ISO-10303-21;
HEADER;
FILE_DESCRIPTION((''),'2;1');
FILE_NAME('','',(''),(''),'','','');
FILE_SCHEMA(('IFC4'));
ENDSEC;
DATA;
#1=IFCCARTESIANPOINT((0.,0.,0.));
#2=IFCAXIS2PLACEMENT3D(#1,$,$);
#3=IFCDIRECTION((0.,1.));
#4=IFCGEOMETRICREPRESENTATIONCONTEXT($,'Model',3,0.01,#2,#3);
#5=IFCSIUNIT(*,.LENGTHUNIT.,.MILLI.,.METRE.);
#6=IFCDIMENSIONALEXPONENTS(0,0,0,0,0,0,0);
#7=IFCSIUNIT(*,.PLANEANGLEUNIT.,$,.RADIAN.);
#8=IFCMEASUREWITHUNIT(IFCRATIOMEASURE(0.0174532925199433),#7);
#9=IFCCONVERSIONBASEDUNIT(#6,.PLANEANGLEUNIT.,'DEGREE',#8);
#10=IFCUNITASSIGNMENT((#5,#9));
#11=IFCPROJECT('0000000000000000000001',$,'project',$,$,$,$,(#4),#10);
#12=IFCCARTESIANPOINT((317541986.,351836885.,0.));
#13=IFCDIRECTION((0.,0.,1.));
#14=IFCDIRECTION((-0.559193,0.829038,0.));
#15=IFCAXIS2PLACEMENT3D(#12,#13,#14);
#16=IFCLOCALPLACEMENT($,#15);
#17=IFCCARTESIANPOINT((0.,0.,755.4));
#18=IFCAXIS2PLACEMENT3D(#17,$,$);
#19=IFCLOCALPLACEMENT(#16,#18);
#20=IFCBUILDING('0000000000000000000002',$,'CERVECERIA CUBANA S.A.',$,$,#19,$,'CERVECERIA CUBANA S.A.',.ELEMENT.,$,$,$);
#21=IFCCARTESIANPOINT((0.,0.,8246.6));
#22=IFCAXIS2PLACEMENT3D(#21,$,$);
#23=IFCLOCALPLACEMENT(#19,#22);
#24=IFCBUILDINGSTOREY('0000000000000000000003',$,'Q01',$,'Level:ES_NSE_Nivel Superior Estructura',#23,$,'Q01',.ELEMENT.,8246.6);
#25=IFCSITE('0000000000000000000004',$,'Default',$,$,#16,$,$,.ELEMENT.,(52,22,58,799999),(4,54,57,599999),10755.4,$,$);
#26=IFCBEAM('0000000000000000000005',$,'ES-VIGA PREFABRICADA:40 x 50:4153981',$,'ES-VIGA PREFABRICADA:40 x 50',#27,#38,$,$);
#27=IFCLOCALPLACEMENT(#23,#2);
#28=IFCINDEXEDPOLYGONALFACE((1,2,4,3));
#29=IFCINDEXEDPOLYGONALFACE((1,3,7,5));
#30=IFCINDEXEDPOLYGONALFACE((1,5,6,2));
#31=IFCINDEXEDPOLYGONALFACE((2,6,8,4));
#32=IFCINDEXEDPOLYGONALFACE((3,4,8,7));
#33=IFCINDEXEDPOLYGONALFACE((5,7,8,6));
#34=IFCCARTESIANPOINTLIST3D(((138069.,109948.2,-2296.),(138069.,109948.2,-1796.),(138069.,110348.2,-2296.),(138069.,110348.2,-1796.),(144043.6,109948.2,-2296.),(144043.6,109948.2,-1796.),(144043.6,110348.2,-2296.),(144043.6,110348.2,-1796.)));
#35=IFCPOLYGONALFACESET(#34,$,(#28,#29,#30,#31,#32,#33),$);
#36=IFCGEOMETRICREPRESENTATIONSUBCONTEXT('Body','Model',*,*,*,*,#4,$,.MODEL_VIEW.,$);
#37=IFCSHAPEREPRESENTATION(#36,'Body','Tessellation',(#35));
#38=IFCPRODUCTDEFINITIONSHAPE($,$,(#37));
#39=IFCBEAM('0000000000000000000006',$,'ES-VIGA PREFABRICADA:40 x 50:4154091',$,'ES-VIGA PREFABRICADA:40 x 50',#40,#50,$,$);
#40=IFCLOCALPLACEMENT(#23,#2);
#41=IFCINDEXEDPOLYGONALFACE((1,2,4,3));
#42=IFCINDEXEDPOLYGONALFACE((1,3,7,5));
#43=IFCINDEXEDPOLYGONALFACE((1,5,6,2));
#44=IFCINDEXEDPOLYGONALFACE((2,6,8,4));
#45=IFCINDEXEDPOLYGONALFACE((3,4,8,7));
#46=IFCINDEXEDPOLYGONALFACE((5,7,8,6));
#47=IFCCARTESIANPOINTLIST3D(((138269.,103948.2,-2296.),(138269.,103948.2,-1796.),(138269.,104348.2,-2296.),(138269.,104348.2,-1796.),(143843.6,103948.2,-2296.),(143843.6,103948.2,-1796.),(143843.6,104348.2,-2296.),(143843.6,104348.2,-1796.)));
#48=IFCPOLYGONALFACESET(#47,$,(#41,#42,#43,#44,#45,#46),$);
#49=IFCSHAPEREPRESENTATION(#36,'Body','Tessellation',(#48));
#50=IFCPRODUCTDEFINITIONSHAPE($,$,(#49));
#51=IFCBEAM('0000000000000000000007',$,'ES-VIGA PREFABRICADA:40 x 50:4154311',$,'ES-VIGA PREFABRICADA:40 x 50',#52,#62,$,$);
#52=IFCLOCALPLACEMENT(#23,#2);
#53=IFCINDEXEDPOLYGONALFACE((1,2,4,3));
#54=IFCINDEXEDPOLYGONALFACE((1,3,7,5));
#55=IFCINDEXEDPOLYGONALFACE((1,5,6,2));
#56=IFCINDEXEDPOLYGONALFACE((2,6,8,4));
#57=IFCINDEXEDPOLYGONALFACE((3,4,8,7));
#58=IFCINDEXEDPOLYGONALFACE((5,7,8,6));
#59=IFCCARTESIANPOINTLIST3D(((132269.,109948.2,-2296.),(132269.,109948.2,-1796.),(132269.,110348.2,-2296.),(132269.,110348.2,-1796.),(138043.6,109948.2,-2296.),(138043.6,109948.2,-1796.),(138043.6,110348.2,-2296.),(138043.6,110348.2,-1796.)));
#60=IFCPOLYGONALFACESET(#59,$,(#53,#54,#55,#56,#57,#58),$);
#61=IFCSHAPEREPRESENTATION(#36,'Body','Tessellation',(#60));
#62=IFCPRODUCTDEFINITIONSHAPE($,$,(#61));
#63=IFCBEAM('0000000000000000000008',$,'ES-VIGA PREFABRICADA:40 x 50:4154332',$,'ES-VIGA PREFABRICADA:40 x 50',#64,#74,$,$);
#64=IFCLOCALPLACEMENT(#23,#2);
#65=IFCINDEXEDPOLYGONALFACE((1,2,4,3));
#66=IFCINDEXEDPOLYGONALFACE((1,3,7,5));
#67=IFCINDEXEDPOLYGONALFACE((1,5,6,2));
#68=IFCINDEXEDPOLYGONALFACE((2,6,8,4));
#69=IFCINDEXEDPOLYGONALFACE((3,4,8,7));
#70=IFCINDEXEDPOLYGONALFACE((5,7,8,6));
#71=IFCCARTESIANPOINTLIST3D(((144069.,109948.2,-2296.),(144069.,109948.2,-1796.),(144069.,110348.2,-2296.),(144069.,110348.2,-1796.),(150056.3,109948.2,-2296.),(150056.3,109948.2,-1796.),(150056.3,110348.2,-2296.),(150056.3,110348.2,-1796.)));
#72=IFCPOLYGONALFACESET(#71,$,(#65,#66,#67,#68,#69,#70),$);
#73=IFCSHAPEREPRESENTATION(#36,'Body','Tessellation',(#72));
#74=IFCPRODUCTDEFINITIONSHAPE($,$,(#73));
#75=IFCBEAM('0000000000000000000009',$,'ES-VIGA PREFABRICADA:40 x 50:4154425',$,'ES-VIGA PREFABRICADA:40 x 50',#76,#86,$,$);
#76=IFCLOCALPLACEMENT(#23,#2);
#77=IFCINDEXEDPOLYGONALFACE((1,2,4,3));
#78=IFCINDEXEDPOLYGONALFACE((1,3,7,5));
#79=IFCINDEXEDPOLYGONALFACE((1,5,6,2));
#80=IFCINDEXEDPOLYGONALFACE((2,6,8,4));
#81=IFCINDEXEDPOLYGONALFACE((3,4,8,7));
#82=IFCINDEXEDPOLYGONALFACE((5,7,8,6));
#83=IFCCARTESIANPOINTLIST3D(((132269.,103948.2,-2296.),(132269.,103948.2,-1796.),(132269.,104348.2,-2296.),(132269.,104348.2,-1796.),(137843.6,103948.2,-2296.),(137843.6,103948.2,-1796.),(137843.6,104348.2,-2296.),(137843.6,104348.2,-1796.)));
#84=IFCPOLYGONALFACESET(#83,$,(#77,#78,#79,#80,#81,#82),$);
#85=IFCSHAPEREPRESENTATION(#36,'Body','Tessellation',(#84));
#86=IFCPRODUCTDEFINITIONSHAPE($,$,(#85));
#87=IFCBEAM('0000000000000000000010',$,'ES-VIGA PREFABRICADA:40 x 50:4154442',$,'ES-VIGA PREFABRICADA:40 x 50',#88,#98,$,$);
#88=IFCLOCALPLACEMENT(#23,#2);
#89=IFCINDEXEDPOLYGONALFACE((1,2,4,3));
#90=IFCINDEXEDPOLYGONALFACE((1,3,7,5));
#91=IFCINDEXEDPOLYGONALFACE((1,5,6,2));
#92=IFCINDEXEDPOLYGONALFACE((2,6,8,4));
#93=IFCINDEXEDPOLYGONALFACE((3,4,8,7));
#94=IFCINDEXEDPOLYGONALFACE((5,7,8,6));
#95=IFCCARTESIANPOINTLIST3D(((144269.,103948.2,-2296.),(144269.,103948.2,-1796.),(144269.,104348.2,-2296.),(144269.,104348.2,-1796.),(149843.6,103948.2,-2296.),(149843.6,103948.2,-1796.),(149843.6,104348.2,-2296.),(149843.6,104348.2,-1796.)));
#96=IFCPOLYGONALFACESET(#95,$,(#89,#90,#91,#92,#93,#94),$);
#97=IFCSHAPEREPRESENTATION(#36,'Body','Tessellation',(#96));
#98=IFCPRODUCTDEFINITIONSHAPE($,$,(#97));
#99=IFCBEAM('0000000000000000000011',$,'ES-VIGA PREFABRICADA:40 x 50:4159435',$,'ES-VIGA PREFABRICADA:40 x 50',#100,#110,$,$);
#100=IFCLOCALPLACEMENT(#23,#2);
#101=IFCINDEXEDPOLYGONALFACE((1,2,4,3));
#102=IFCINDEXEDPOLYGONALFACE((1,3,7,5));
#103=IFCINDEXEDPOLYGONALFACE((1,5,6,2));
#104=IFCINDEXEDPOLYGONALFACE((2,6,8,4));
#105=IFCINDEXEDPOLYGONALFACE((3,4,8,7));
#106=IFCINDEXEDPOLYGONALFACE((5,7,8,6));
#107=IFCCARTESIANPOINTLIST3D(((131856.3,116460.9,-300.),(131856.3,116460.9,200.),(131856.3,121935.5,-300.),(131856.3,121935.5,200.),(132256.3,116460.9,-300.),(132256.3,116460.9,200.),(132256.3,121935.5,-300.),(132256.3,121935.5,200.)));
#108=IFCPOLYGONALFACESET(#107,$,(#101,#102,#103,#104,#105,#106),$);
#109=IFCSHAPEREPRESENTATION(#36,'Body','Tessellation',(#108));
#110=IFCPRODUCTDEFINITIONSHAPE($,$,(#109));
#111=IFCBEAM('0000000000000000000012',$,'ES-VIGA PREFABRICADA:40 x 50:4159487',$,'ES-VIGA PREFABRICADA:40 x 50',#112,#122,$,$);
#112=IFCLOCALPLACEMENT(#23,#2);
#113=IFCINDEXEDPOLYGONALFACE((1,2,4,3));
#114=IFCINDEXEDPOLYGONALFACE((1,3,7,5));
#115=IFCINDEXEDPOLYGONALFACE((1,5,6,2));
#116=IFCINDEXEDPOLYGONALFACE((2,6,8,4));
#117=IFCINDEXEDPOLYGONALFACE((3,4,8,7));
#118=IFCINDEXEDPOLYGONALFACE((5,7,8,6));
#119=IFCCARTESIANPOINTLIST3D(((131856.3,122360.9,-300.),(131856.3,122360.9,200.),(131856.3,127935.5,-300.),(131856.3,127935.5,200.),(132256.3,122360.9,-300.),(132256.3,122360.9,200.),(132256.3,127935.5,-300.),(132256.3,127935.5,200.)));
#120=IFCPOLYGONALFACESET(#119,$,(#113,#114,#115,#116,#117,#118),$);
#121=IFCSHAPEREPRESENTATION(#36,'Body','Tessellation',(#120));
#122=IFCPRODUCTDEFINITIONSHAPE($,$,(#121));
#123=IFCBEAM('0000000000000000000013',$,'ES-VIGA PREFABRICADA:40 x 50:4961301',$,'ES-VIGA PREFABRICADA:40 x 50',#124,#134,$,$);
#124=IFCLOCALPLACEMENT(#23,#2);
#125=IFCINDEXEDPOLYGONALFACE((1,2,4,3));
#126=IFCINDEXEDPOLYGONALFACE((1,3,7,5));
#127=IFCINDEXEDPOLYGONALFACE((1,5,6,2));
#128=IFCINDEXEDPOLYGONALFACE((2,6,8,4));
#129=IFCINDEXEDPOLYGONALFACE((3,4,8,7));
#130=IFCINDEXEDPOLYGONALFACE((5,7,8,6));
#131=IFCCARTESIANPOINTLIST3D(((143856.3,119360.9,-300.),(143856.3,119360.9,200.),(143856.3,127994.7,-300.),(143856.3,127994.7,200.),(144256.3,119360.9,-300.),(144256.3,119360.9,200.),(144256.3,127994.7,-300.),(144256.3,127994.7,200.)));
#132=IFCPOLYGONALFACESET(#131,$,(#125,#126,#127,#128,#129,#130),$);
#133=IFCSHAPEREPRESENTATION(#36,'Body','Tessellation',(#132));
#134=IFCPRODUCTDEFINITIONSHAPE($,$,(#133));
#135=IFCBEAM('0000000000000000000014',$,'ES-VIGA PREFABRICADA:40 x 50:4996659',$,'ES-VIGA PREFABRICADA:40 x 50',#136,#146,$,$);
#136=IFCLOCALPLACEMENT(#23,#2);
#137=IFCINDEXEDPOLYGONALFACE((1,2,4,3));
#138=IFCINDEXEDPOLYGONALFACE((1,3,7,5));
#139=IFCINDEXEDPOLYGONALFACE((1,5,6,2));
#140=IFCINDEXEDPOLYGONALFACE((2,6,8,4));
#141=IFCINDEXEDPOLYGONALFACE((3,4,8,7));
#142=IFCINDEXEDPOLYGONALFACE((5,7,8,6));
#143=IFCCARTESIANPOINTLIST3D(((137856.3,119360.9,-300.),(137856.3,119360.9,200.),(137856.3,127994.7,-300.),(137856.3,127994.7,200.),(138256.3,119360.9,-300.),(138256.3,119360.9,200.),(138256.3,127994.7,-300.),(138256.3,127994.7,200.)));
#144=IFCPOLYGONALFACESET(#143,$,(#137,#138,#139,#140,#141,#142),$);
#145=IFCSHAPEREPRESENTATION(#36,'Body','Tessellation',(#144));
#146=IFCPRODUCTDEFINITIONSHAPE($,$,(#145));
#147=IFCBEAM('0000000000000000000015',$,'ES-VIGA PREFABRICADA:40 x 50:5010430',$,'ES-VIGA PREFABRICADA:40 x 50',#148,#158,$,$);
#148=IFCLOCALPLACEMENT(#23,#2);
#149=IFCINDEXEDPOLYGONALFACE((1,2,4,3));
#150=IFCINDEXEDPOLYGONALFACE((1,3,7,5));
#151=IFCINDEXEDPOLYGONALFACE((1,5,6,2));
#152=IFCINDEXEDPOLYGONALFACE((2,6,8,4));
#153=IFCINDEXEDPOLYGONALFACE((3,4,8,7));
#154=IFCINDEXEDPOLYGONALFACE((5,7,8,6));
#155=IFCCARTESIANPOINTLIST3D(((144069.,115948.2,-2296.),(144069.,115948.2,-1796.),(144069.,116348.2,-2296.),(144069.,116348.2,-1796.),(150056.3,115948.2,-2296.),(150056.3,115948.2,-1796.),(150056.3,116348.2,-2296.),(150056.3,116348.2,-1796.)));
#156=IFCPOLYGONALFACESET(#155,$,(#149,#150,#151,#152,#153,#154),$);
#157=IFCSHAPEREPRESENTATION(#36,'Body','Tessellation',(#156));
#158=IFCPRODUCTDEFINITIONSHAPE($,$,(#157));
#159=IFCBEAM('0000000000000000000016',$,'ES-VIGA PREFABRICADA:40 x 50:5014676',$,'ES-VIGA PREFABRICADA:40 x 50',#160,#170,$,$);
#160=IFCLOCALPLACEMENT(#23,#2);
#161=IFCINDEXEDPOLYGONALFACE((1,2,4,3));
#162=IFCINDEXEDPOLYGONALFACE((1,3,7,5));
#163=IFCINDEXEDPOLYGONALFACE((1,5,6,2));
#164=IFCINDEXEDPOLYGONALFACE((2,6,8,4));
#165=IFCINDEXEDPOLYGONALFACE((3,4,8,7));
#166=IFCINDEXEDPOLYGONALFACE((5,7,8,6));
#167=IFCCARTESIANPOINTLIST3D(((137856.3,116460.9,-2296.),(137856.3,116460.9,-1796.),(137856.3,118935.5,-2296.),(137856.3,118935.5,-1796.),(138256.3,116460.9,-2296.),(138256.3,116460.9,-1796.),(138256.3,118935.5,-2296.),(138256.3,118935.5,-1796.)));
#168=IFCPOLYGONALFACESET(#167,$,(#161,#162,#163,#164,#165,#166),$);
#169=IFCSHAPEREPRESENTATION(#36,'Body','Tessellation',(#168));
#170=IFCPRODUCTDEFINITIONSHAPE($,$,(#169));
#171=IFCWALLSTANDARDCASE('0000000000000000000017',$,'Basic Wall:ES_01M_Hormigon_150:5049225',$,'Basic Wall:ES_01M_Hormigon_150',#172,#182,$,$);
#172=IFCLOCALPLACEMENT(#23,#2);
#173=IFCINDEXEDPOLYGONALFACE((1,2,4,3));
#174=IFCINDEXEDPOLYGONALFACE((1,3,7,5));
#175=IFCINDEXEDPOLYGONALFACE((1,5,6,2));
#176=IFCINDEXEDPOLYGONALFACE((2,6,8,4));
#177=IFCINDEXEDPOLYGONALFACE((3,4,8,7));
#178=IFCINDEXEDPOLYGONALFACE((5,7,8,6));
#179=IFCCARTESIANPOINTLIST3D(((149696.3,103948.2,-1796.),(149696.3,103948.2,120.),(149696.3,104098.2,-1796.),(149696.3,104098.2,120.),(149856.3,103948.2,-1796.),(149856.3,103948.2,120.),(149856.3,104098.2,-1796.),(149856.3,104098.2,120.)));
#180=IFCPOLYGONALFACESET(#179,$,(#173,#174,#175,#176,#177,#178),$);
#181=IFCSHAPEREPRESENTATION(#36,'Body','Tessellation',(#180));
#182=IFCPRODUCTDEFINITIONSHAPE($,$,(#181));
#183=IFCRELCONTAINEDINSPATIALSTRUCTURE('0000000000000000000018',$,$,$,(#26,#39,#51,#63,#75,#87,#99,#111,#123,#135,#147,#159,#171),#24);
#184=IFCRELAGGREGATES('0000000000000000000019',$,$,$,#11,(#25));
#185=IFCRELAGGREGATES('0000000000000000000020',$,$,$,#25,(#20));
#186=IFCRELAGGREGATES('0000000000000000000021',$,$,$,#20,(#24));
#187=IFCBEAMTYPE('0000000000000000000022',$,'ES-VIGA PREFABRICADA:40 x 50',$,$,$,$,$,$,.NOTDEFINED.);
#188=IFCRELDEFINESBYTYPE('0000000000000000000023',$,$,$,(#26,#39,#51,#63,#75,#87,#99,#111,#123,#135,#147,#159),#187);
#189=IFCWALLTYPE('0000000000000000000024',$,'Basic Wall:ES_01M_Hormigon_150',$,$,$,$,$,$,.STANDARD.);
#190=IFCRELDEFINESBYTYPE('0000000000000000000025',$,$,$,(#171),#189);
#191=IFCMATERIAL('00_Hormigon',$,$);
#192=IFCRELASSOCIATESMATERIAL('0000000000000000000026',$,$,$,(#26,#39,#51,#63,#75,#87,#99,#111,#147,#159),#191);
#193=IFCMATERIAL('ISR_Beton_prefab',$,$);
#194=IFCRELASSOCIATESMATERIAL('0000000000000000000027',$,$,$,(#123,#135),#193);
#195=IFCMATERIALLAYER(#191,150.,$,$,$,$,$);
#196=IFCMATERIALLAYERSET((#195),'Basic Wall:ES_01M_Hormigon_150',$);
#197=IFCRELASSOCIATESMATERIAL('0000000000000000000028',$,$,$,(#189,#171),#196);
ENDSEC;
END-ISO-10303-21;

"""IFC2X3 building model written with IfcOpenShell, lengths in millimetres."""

from ifc_helpers import new_model, entity, si_unit, converted_unit, direction, frame, frame_2d, origin, place, context, subcontext, project, spatial, rectangle, extrude, material, layer, layer_set, layer_usage, type_object, element, save


model = new_model("IFC2X3")

# Units and contexts
model_context = context("Model", 3, precision=0.01, world=origin(), true_north=direction((0.0, 1.0)))
body_context = subcontext(model_context, "Body", "Model", "MODEL_VIEW")
ifc_project = project(units=[si_unit("LENGTHUNIT", "METRE", prefix="MILLI"), converted_unit("PLANEANGLEUNIT", "DEGREE", entity("IfcRatioMeasure", 0.0174532925199433), si_unit("PLANEANGLEUNIT", "RADIAN"), dimensions=[0, 0, 0, 0, 0, 0, 0])], contexts=[model_context])

# Site, building, storey
site_placement = place(None, frame((317541986.0, 351836885.0, 0.0), z_axis=(0.0, 0.0, 1.0), x_axis=(-0.559193, 0.829038, 0.0)))
site = spatial("IfcSite", under=ifc_project, at=site_placement, Name="Default", CompositionType="ELEMENT", RefLatitude=(52, 22, 58, 799999), RefLongitude=(4, 54, 57, 599999), RefElevation=10755.4)
building_placement = place(site_placement, frame((0.0, 0.0, 755.4)))
building = spatial("IfcBuilding", under=site, at=building_placement, Name="CERVECERIA CUBANA S.A.", LongName="CERVECERIA CUBANA S.A.", CompositionType="ELEMENT")
storey_placement = place(building_placement, frame((0.0, 0.0, 8246.6)))
storey = spatial("IfcBuildingStorey", under=building, at=storey_placement, Name="Q01", ObjectType="Level:ES_NSE_Nivel Superior Estructura", LongName="Q01", CompositionType="ELEMENT", Elevation=8246.6)

# Beams
ifc_material_1 = material(Name="00_Hormigon")
beam_type = type_object("IfcBeamType", Name="ES-VIGA PREFABRICADA:40 x 50", PredefinedType="NOTDEFINED")
beam_1_placement = place(storey_placement, frame((138056.3, 110148.2, -1796.0)))
element("IfcBeam", 1, at=beam_1_placement, inside=storey, type_object=beam_type, material=ifc_material_1, Name="ES-VIGA PREFABRICADA:40 x 50:4153981", ObjectType="ES-VIGA PREFABRICADA:40 x 50", context=body_context, shape_type="SweptSolid", body=[
    extrude(rectangle(XDim=500.0, YDim=400.0, at=frame_2d((0.0, 0.0), x_axis=(1.0, 0.0))), frame((12.7, 0.0, -250.0), z_axis=(1.0, 0.0, 0.0), x_axis=(0.0, 0.0, -1.0)), (0.0, 0.0, 1.0), 5974.6),
])
beam_2_placement = place(storey_placement, frame((138056.3, 104148.2, -1796.0)))
element("IfcBeam", 2, at=beam_2_placement, inside=storey, type_object=beam_type, material=ifc_material_1, Name="ES-VIGA PREFABRICADA:40 x 50:4154091", ObjectType="ES-VIGA PREFABRICADA:40 x 50", context=body_context, shape_type="SweptSolid", body=[
    extrude(rectangle(XDim=500.0, YDim=400.0, at=frame_2d((0.0, 0.0), x_axis=(1.0, 0.0))), frame((212.7, 0.0, -250.0), z_axis=(1.0, 0.0, 0.0), x_axis=(0.0, 0.0, -1.0)), (0.0, 0.0, 1.0), 5574.6),
])
beam_3_placement = place(storey_placement, frame((131906.3, 110148.2, -1796.0)))
element("IfcBeam", 3, at=beam_3_placement, inside=storey, type_object=beam_type, material=ifc_material_1, Name="ES-VIGA PREFABRICADA:40 x 50:4154311", ObjectType="ES-VIGA PREFABRICADA:40 x 50", context=body_context, shape_type="SweptSolid", body=[
    extrude(rectangle(XDim=500.0, YDim=400.0, at=frame_2d((0.0, 0.0), x_axis=(1.0, 0.0))), frame((362.7, 0.0, -250.0), z_axis=(1.0, 0.0, 0.0), x_axis=(0.0, 0.0, -1.0)), (0.0, 0.0, 1.0), 5774.6),
])
beam_4_placement = place(storey_placement, frame((144056.3, 110148.2, -1796.0)))
element("IfcBeam", 4, at=beam_4_placement, inside=storey, type_object=beam_type, material=ifc_material_1, Name="ES-VIGA PREFABRICADA:40 x 50:4154332", ObjectType="ES-VIGA PREFABRICADA:40 x 50", context=body_context, shape_type="SweptSolid", body=[
    extrude(rectangle(XDim=500.0, YDim=400.0, at=frame_2d((0.0, 0.0), x_axis=(1.0, 0.0))), frame((12.7, 0.0, -250.0), z_axis=(1.0, 0.0, 0.0), x_axis=(0.0, 0.0, -1.0)), (0.0, 0.0, 1.0), 5987.3),
])
beam_5_placement = place(storey_placement, frame((131906.3, 104148.2, -1796.0)))
element("IfcBeam", 5, at=beam_5_placement, inside=storey, type_object=beam_type, material=ifc_material_1, Name="ES-VIGA PREFABRICADA:40 x 50:4154425", ObjectType="ES-VIGA PREFABRICADA:40 x 50", context=body_context, shape_type="SweptSolid", body=[
    extrude(rectangle(XDim=500.0, YDim=400.0, at=frame_2d((0.0, 0.0), x_axis=(1.0, 0.0))), frame((362.7, 0.0, -250.0), z_axis=(1.0, 0.0, 0.0), x_axis=(0.0, 0.0, -1.0)), (0.0, 0.0, 1.0), 5574.6),
])
beam_6_placement = place(storey_placement, frame((144056.3, 104148.2, -1796.0)))
element("IfcBeam", 6, at=beam_6_placement, inside=storey, type_object=beam_type, material=ifc_material_1, Name="ES-VIGA PREFABRICADA:40 x 50:4154442", ObjectType="ES-VIGA PREFABRICADA:40 x 50", context=body_context, shape_type="SweptSolid", body=[
    extrude(rectangle(XDim=500.0, YDim=400.0, at=frame_2d((0.0, 0.0), x_axis=(1.0, 0.0))), frame((212.7, 0.0, -250.0), z_axis=(1.0, 0.0, 0.0), x_axis=(0.0, 0.0, -1.0)), (0.0, 0.0, 1.0), 5574.6),
])
beam_7_placement = place(storey_placement, frame((132056.3, 116283.2, 200.0), z_axis=(0.0, 0.0, 1.0), x_axis=(0.0, 1.0, 0.0)))
element("IfcBeam", 7, at=beam_7_placement, inside=storey, type_object=beam_type, material=ifc_material_1, Name="ES-VIGA PREFABRICADA:40 x 50:4159435", ObjectType="ES-VIGA PREFABRICADA:40 x 50", context=body_context, shape_type="SweptSolid", body=[
    extrude(rectangle(XDim=500.0, YDim=400.0, at=frame_2d((0.0, 0.0), x_axis=(1.0, 0.0))), frame((177.7, 0.0, -250.0), z_axis=(1.0, 0.0, 0.0), x_axis=(0.0, 0.0, -1.0)), (0.0, 0.0, 1.0), 5474.6),
])
beam_8_placement = place(storey_placement, frame((132056.3, 122158.2, 200.0), z_axis=(0.0, 0.0, 1.0), x_axis=(0.0, 1.0, 0.0)))
element("IfcBeam", 8, at=beam_8_placement, inside=storey, type_object=beam_type, material=ifc_material_1, Name="ES-VIGA PREFABRICADA:40 x 50:4159487", ObjectType="ES-VIGA PREFABRICADA:40 x 50", context=body_context, shape_type="SweptSolid", body=[
    extrude(rectangle(XDim=500.0, YDim=400.0, at=frame_2d((0.0, 0.0), x_axis=(1.0, 0.0))), frame((202.7, 0.0, -250.0), z_axis=(1.0, 0.0, 0.0), x_axis=(0.0, 0.0, -1.0)), (0.0, 0.0, 1.0), 5574.6),
])
ifc_material_2 = material(Name="ISR_Beton_prefab")
beam_9_placement = place(storey_placement, frame((144056.3, 119148.2, 200.0), z_axis=(0.0, 0.0, 1.0), x_axis=(0.0, 1.0, 0.0)))
element("IfcBeam", 9, at=beam_9_placement, inside=storey, type_object=beam_type, material=ifc_material_2, Name="ES-VIGA PREFABRICADA:40 x 50:4961301", ObjectType="ES-VIGA PREFABRICADA:40 x 50", context=body_context, shape_type="SweptSolid", body=[
    extrude(rectangle(XDim=500.0, YDim=400.0, at=frame_2d((0.0, 0.0), x_axis=(1.0, 0.0))), frame((212.7, 0.0, -250.0), z_axis=(1.0, 0.0, 0.0), x_axis=(0.0, 0.0, -1.0)), (0.0, 0.0, 1.0), 8633.8),
])
beam_10_placement = place(storey_placement, frame((138056.3, 119148.2, 200.0), z_axis=(0.0, 0.0, 1.0), x_axis=(0.0, 1.0, 0.0)))
element("IfcBeam", 10, at=beam_10_placement, inside=storey, type_object=beam_type, material=ifc_material_2, Name="ES-VIGA PREFABRICADA:40 x 50:4996659", ObjectType="ES-VIGA PREFABRICADA:40 x 50", context=body_context, shape_type="SweptSolid", body=[
    extrude(rectangle(XDim=500.0, YDim=400.0, at=frame_2d((0.0, 0.0), x_axis=(1.0, 0.0))), frame((212.7, 0.0, -250.0), z_axis=(1.0, 0.0, 0.0), x_axis=(0.0, 0.0, -1.0)), (0.0, 0.0, 1.0), 8633.8),
])
beam_11_placement = place(storey_placement, frame((144056.3, 116148.2, -1796.0)))
element("IfcBeam", 11, at=beam_11_placement, inside=storey, type_object=beam_type, material=ifc_material_1, Name="ES-VIGA PREFABRICADA:40 x 50:5010430", ObjectType="ES-VIGA PREFABRICADA:40 x 50", context=body_context, shape_type="SweptSolid", body=[
    extrude(rectangle(XDim=500.0, YDim=400.0, at=frame_2d((0.0, 0.0), x_axis=(1.0, 0.0))), frame((12.7, 0.0, -250.0), z_axis=(1.0, 0.0, 0.0), x_axis=(0.0, 0.0, -1.0)), (0.0, 0.0, 1.0), 5987.3),
])
beam_12_placement = place(storey_placement, frame((138056.3, 118948.2, -1796.0), z_axis=(0.0, 0.0, 1.0), x_axis=(0.0, -1.0, 0.0)))
element("IfcBeam", 12, at=beam_12_placement, inside=storey, type_object=beam_type, material=ifc_material_1, Name="ES-VIGA PREFABRICADA:40 x 50:5014676", ObjectType="ES-VIGA PREFABRICADA:40 x 50", context=body_context, shape_type="SweptSolid", body=[
    extrude(rectangle(XDim=500.0, YDim=400.0, at=frame_2d((0.0, 0.0), x_axis=(1.0, 0.0))), frame((12.7, 0.0, -250.0), z_axis=(1.0, 0.0, 0.0), x_axis=(0.0, 0.0, -1.0)), (0.0, 0.0, 1.0), 2474.6),
])

# Wall
ifc_layer_1 = layer(ifc_material_1, 150.0)
ifc_layer_set_1 = layer_set([ifc_layer_1], Name="Basic Wall:ES_01M_Hormigon_150")
ifc_layer_usage_1 = layer_usage(ifc_layer_set_1, "AXIS2", "NEGATIVE", 75.0)
wall_type = type_object("IfcWallType", Name="Basic Wall:ES_01M_Hormigon_150", PredefinedType="STANDARD", material=ifc_layer_set_1)
wall_1_placement = place(storey_placement, frame((149696.3, 104023.2, -1796.0)))
element("IfcWallStandardCase", 13, at=wall_1_placement, inside=storey, type_object=wall_type, material=ifc_layer_usage_1, Name="Basic Wall:ES_01M_Hormigon_150:5049225", ObjectType="Basic Wall:ES_01M_Hormigon_150", context=body_context, shape_type="SweptSolid", body=[
    extrude(rectangle(XDim=160.0, YDim=150.0, at=frame_2d((80.0, 0.0), x_axis=(-1.0, 0.0))), origin(), (0.0, 0.0, 1.0), 1916.0),
])

save(model, "model.ifc")
